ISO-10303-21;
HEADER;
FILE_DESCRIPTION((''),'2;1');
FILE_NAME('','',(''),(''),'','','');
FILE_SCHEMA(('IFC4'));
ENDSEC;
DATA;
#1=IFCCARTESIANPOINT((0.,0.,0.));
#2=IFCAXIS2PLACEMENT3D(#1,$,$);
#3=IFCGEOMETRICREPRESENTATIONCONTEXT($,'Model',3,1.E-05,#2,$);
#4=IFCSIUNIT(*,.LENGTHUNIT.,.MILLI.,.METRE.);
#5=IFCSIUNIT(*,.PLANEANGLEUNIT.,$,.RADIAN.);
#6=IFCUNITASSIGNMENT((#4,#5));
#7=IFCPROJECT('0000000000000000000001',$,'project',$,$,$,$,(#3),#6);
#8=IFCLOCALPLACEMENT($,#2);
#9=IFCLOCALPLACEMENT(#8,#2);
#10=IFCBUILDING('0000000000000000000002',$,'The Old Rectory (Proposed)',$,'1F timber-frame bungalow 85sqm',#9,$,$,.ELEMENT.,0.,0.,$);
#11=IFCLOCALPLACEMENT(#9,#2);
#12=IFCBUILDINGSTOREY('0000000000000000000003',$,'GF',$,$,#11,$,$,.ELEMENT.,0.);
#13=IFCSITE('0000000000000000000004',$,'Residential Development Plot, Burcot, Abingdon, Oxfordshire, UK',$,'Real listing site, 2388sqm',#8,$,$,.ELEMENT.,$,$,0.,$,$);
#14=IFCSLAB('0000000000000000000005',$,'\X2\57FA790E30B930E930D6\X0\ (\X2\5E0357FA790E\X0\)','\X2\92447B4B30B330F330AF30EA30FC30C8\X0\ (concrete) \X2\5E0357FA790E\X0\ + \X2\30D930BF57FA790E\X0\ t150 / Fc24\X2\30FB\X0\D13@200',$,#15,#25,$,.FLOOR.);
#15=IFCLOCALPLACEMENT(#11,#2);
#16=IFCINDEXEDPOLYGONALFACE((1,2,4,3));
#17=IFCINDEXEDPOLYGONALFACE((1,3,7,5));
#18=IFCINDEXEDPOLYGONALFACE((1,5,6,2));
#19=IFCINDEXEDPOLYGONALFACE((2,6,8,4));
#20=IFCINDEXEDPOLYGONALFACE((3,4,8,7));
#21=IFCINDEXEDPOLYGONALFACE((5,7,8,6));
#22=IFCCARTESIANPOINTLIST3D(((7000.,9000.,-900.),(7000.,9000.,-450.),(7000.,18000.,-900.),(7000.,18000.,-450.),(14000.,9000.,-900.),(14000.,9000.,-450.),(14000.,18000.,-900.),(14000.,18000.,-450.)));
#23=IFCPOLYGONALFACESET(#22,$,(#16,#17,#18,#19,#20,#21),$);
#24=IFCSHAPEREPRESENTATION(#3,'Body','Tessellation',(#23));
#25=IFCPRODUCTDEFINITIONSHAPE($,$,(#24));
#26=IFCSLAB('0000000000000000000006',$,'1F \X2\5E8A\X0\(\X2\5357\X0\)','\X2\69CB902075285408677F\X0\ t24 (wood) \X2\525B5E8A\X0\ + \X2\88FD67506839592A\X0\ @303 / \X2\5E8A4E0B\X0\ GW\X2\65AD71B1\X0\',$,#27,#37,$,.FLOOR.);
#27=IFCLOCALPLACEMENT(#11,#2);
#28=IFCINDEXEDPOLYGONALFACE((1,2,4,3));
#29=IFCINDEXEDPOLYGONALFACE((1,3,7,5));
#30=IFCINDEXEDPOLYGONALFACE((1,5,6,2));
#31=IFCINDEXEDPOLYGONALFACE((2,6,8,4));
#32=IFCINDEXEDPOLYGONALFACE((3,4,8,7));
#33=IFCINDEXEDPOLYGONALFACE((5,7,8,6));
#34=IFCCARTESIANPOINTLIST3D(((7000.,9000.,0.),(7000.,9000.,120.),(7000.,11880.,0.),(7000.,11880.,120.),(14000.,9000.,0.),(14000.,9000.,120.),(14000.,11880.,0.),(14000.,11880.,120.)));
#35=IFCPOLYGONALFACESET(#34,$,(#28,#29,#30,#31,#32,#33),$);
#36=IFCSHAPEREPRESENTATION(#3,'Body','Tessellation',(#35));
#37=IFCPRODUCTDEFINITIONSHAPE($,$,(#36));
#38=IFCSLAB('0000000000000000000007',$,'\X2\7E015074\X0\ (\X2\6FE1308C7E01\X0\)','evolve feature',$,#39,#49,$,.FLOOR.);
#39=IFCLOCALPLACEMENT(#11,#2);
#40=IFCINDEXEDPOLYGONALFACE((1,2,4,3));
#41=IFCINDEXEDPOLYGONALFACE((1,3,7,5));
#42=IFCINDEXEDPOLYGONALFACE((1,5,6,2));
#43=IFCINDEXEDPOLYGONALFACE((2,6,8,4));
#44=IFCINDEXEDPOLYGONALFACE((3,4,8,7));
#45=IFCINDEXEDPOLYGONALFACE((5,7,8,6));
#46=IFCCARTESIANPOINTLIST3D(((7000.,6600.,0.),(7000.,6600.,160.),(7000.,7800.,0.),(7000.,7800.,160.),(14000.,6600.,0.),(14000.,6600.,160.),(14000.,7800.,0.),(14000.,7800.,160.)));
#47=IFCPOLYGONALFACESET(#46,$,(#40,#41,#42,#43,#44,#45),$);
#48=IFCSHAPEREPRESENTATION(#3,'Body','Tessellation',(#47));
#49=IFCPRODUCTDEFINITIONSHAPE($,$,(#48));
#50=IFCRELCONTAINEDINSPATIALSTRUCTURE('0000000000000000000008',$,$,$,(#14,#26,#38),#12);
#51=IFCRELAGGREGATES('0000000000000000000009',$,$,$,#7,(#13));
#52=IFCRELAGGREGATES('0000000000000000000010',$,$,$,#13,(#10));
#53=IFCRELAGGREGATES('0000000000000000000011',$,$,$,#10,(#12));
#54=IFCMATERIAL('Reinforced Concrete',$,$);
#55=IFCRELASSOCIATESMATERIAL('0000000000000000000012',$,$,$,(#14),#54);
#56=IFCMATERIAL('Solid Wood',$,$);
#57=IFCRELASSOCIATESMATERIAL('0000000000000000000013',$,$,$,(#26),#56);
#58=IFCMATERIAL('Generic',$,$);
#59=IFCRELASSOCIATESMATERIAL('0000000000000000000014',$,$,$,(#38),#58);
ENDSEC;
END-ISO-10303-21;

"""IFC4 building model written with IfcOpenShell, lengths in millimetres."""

from ifc_helpers import new_model, si_unit, frame, frame_2d, origin, place, context, project, spatial, rectangle, extrude, material, element, save


model = new_model("IFC4")

# Units and contexts
model_context = context("Model", 3, precision=1e-05, world=origin())
ifc_project = project(units=[si_unit("LENGTHUNIT", "METRE", prefix="MILLI"), si_unit("PLANEANGLEUNIT", "RADIAN")], contexts=[model_context])

# Site, building, storey
site_placement = place(None, origin())
site = spatial("IfcSite", under=ifc_project, at=site_placement, Name="Residential Development Plot, Burcot, Abingdon, Oxfordshire, UK", ObjectType="Real listing site, 2388sqm", CompositionType="ELEMENT", RefElevation=0.0)
building_placement = place(site_placement, origin())
building = spatial("IfcBuilding", under=site, at=building_placement, Name="The Old Rectory (Proposed)", ObjectType="1F timber-frame bungalow 85sqm", CompositionType="ELEMENT", ElevationOfRefHeight=0.0, ElevationOfTerrain=0.0)
storey_placement = place(building_placement, origin())
storey = spatial("IfcBuildingStorey", under=building, at=storey_placement, Name="GF", CompositionType="ELEMENT", Elevation=0.0)

# Slabs
ifc_material_1 = material(Name="Reinforced Concrete")
slab_1_placement = place(storey_placement, frame((3500.0, 4500.0, -450.0)))
element("IfcSlab", 1, at=slab_1_placement, inside=storey, material=ifc_material_1, Name="基礎スラブ (布基礎)", Description="鉄筋コンクリート (concrete) 布基礎 + ベタ基礎 t150 / Fc24・D13@200", PredefinedType="FLOOR", context=model_context, shape_type="SweptSolid", body=[
    extrude(rectangle(XDim=7000.0, YDim=9000.0, at=frame_2d((3500.0, 4500.0))), frame((3500.0, 4500.0, -450.0)), (0.0, 0.0, 1.0), 450.0),
])
ifc_material_2 = material(Name="Solid Wood")
slab_2_placement = place(storey_placement, frame((3500.0, 4500.0, 0.0)))
element("IfcSlab", 2, at=slab_2_placement, inside=storey, material=ifc_material_2, Name="1F 床(南)", Description="構造用合板 t24 (wood) 剛床 + 製材根太 @303 / 床下 GW断熱", PredefinedType="FLOOR", context=model_context, shape_type="SweptSolid", body=[
    extrude(rectangle(XDim=7000.0, YDim=2880.0, at=frame_2d((3500.0, 1440.0))), frame((3500.0, 4500.0, 0.0)), (0.0, 0.0, 1.0), 120.0),
])
ifc_material_3 = material(Name="Generic")
slab_3_placement = place(storey_placement, frame((3500.0, 3300.0, 0.0)))
element("IfcSlab", 3, at=slab_3_placement, inside=storey, material=ifc_material_3, Name="縁側 (濡れ縁)", Description="evolve feature", PredefinedType="FLOOR", context=model_context, shape_type="SweptSolid", body=[
    extrude(rectangle(XDim=7000.0, YDim=1200.0, at=frame_2d((3500.0, 600.0))), frame((3500.0, 3300.0, 0.0)), (0.0, 0.0, 1.0), 160.0),
])

save(model, "model.ifc")
